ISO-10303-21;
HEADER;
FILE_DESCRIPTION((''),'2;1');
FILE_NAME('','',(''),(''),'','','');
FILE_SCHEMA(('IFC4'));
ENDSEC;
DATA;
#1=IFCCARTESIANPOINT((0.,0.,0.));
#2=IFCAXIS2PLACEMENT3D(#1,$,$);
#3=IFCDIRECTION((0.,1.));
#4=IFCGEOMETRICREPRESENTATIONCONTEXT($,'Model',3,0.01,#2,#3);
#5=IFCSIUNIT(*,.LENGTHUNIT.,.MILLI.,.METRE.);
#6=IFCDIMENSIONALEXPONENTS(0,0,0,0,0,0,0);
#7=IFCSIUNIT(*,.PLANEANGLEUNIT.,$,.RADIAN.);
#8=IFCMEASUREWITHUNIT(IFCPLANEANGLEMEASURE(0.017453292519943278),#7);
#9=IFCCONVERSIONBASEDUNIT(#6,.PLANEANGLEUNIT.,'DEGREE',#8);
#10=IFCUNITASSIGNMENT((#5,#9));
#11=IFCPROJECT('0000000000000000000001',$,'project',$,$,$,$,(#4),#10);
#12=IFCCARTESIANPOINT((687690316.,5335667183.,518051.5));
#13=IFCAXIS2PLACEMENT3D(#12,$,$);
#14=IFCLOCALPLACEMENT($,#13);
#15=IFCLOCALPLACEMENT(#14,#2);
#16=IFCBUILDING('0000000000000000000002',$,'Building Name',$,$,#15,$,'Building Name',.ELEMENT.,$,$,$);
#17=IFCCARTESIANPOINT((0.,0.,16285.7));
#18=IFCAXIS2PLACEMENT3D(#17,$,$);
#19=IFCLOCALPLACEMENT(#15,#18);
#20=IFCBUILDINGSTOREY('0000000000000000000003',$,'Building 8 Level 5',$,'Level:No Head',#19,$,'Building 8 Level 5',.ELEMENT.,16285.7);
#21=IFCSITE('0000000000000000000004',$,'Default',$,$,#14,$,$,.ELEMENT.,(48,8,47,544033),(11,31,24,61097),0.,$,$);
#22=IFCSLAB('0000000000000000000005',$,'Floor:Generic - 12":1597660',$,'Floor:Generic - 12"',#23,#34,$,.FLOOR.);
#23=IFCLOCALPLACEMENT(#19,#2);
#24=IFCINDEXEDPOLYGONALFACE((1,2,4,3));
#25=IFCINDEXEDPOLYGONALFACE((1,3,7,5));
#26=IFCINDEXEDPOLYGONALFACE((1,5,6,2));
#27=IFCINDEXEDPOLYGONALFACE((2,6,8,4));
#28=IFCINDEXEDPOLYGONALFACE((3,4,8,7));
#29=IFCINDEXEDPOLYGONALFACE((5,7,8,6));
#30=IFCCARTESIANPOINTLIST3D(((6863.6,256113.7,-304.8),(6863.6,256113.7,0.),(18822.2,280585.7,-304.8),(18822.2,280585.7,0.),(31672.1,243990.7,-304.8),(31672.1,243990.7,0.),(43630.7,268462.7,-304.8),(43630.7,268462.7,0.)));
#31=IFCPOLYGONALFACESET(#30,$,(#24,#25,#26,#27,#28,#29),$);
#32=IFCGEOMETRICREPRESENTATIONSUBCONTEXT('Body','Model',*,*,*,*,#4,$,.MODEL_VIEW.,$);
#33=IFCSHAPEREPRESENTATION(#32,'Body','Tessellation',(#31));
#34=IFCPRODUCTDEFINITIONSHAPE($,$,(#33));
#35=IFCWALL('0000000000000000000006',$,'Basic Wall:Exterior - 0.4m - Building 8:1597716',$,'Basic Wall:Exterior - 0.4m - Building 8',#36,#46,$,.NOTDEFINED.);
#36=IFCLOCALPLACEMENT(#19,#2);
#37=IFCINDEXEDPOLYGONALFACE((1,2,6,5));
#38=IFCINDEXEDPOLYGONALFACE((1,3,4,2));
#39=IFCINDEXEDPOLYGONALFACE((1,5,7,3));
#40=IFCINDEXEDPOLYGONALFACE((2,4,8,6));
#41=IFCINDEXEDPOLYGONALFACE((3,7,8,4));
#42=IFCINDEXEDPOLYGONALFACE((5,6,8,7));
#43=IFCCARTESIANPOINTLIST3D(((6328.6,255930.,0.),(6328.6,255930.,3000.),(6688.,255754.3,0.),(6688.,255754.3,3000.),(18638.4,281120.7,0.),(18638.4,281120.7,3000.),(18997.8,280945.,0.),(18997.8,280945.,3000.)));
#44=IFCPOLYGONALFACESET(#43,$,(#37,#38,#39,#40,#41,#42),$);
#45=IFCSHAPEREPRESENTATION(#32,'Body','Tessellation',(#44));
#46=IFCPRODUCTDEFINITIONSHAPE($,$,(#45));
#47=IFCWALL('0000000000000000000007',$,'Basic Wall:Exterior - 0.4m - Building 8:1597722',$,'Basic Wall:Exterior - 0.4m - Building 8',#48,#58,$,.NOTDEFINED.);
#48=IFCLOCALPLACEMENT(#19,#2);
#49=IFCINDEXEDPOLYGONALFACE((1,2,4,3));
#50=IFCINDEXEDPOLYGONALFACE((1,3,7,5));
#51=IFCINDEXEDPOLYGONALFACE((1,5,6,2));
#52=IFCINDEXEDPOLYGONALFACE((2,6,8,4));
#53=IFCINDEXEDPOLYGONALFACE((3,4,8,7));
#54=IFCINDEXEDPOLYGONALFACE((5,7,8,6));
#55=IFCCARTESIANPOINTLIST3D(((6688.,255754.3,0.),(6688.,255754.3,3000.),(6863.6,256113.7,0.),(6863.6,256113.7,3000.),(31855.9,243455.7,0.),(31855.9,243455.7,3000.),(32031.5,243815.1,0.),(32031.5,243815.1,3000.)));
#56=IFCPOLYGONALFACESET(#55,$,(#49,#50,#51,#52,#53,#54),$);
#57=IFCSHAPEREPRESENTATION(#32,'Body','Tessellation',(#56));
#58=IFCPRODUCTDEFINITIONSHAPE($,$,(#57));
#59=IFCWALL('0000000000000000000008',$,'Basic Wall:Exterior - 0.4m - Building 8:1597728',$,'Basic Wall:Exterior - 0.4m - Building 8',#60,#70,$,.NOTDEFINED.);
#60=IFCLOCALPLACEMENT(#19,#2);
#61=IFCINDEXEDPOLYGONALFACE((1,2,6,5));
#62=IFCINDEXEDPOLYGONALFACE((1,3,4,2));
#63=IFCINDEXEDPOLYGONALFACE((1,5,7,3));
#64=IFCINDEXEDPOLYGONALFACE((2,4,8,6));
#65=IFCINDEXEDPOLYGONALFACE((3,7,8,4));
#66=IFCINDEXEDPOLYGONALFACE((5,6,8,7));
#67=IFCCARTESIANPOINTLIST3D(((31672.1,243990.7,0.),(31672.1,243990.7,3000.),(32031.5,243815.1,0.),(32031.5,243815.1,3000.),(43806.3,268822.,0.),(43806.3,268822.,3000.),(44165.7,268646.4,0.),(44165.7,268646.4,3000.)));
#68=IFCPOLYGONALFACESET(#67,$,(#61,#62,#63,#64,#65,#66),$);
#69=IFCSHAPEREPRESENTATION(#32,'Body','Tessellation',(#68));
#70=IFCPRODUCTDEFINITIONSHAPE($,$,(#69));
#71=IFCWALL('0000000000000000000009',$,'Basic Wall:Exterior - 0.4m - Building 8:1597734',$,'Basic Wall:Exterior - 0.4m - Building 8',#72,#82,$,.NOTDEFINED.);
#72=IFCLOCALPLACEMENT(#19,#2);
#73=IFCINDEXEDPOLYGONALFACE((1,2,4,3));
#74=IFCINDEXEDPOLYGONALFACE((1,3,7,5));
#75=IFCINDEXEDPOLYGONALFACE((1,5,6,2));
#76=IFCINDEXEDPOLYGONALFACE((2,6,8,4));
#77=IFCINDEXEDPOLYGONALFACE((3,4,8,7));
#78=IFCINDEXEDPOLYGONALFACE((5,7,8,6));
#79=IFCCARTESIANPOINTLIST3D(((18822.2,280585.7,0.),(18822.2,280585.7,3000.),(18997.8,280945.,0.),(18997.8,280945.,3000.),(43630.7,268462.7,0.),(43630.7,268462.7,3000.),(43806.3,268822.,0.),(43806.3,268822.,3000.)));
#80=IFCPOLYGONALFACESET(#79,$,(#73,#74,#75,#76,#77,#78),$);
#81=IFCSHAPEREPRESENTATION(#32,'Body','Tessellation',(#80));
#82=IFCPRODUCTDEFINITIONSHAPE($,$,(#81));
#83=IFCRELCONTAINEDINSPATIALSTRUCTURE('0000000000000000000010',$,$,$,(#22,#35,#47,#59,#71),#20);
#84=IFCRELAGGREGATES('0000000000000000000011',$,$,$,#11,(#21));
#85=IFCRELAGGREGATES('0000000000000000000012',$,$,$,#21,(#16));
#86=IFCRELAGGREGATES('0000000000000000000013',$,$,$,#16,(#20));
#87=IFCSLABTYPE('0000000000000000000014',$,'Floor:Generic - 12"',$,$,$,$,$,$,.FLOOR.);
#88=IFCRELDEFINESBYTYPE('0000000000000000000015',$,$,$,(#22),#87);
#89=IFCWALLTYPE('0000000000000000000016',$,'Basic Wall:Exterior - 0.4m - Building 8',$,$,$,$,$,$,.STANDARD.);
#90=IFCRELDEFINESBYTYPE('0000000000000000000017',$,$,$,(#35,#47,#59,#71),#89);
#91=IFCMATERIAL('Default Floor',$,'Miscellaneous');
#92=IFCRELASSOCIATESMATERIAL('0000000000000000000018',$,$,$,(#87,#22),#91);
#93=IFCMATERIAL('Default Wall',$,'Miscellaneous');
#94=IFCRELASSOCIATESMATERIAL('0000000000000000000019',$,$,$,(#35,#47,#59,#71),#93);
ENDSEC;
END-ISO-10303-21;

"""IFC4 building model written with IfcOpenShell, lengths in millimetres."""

from ifc_helpers import new_model, entity, si_unit, converted_unit, direction, frame, origin, place, context, subcontext, project, spatial, indexed_curve, outline, extrude, material, type_object, element, save


model = new_model("IFC4")

# Units and contexts
model_context = context("Model", 3, precision=0.01, world=origin(), true_north=direction((0.0, 1.0)))
body_context = subcontext(model_context, "Body", "Model", "MODEL_VIEW")
ifc_project = project(units=[si_unit("LENGTHUNIT", "METRE", prefix="MILLI"), converted_unit("PLANEANGLEUNIT", "DEGREE", entity("IfcPlaneAngleMeasure", 0.017453292519943278), si_unit("PLANEANGLEUNIT", "RADIAN"), dimensions=[0, 0, 0, 0, 0, 0, 0])], contexts=[model_context])

# Site, building, storey
site_placement = place(None, frame((687690316.0, 5335667183.0, 518051.5)))
site = spatial("IfcSite", under=ifc_project, at=site_placement, Name="Default", CompositionType="ELEMENT", RefLatitude=(48, 8, 47, 544033), RefLongitude=(11, 31, 24, 61097), RefElevation=0.0)
building_placement = place(site_placement, origin())
building = spatial("IfcBuilding", under=site, at=building_placement, Name="Building Name", LongName="Building Name", CompositionType="ELEMENT")
storey_placement = place(building_placement, frame((0.0, 0.0, 16285.7)))
storey = spatial("IfcBuildingStorey", under=building, at=storey_placement, Name="Building 8 Level 5", ObjectType="Level:No Head", LongName="Building 8 Level 5", CompositionType="ELEMENT", Elevation=16285.7)

# Slab
ifc_material_1 = material(Name="Default Floor", Category="Miscellaneous")
slab_type = type_object("IfcSlabType", Name="Floor:Generic - 12\"", PredefinedType="FLOOR", material=ifc_material_1)
slab_placement = place(storey_placement, origin())
element("IfcSlab", 1, at=slab_placement, inside=storey, type_object=slab_type, material=ifc_material_1, Name="Floor:Generic - 12\":1597660", ObjectType="Floor:Generic - 12\"", PredefinedType="FLOOR", context=body_context, shape_type="SweptSolid", body=[
    extrude(outline(indexed_curve([(-13806.1, -13618.8), (13806.1, -13618.8), (13806.1, 13618.8), (-13806.1, 13618.8), (-13806.1, -13618.8)], self_intersect=False)), frame((25247.1, 262288.2, 0.0), z_axis=(0.0, 0.0, -1.0), x_axis=(0.898464, -0.439046, 0.0)), (0.0, 0.0, 1.0), 304.8),
])

# Walls
ifc_material_2 = material(Name="Default Wall", Category="Miscellaneous")
wall_type = type_object("IfcWallType", Name="Basic Wall:Exterior - 0.4m - Building 8", PredefinedType="STANDARD")
wall_1_placement = place(storey_placement, frame((18818.1, 281032.9, 0.0), z_axis=(0.0, 0.0, 1.0), x_axis=(-0.439046, -0.898464, 0.0)))
element("IfcWall", 2, at=wall_1_placement, inside=storey, type_object=wall_type, material=ifc_material_2, Name="Basic Wall:Exterior - 0.4m - Building 8:1597716", ObjectType="Basic Wall:Exterior - 0.4m - Building 8", PredefinedType="NOTDEFINED", context=body_context, shape_type="SweptSolid", body=[
    extrude(outline(indexed_curve([(28037.5, 200.0), (0.0, 200.0), (0.0, -200.0), (28037.5, -200.0), (28037.5, 200.0)], self_intersect=False)), origin(), (0.0, 0.0, 1.0), 3000.0),
])
wall_2_placement = place(storey_placement, frame((6775.8, 255934.0, 0.0), z_axis=(0.0, 0.0, 1.0), x_axis=(0.898464, -0.439046, 0.0)))
element("IfcWall", 3, at=wall_2_placement, inside=storey, type_object=wall_type, material=ifc_material_2, Name="Basic Wall:Exterior - 0.4m - Building 8:1597722", ObjectType="Basic Wall:Exterior - 0.4m - Building 8", PredefinedType="NOTDEFINED", context=body_context, shape_type="SweptSolid", body=[
    extrude(outline(indexed_curve([(28012.1, 200.0), (0.0, 200.0), (0.0, -200.0), (28012.1, -200.0), (28012.1, 200.0)], self_intersect=False)), origin(), (0.0, 0.0, 1.0), 3000.0),
])
wall_3_placement = place(storey_placement, frame((31851.8, 243902.9, 0.0), z_axis=(0.0, 0.0, 1.0), x_axis=(0.439046, 0.898464, 0.0)))
element("IfcWall", 4, at=wall_3_placement, inside=storey, type_object=wall_type, material=ifc_material_2, Name="Basic Wall:Exterior - 0.4m - Building 8:1597728", ObjectType="Basic Wall:Exterior - 0.4m - Building 8", PredefinedType="NOTDEFINED", context=body_context, shape_type="SweptSolid", body=[
    extrude(outline(indexed_curve([(27637.5, 200.0), (0.0, 200.0), (0.0, -200.0), (27637.5, -200.0), (27637.5, 200.0)], self_intersect=False)), origin(), (0.0, 0.0, 1.0), 3000.0),
])
wall_4_placement = place(storey_placement, frame((43718.5, 268642.3, 0.0), z_axis=(0.0, 0.0, 1.0), x_axis=(-0.898464, 0.439046, 0.0)))
element("IfcWall", 5, at=wall_4_placement, inside=storey, type_object=wall_type, material=ifc_material_2, Name="Basic Wall:Exterior - 0.4m - Building 8:1597734", ObjectType="Basic Wall:Exterior - 0.4m - Building 8", PredefinedType="NOTDEFINED", context=body_context, shape_type="SweptSolid", body=[
    extrude(outline(indexed_curve([(27612.1, 200.0), (0.0, 200.0), (0.0, -200.0), (27612.1, -200.0), (27612.1, 200.0)], self_intersect=False)), origin(), (0.0, 0.0, 1.0), 3000.0),
])

save(model, "model.ifc")
